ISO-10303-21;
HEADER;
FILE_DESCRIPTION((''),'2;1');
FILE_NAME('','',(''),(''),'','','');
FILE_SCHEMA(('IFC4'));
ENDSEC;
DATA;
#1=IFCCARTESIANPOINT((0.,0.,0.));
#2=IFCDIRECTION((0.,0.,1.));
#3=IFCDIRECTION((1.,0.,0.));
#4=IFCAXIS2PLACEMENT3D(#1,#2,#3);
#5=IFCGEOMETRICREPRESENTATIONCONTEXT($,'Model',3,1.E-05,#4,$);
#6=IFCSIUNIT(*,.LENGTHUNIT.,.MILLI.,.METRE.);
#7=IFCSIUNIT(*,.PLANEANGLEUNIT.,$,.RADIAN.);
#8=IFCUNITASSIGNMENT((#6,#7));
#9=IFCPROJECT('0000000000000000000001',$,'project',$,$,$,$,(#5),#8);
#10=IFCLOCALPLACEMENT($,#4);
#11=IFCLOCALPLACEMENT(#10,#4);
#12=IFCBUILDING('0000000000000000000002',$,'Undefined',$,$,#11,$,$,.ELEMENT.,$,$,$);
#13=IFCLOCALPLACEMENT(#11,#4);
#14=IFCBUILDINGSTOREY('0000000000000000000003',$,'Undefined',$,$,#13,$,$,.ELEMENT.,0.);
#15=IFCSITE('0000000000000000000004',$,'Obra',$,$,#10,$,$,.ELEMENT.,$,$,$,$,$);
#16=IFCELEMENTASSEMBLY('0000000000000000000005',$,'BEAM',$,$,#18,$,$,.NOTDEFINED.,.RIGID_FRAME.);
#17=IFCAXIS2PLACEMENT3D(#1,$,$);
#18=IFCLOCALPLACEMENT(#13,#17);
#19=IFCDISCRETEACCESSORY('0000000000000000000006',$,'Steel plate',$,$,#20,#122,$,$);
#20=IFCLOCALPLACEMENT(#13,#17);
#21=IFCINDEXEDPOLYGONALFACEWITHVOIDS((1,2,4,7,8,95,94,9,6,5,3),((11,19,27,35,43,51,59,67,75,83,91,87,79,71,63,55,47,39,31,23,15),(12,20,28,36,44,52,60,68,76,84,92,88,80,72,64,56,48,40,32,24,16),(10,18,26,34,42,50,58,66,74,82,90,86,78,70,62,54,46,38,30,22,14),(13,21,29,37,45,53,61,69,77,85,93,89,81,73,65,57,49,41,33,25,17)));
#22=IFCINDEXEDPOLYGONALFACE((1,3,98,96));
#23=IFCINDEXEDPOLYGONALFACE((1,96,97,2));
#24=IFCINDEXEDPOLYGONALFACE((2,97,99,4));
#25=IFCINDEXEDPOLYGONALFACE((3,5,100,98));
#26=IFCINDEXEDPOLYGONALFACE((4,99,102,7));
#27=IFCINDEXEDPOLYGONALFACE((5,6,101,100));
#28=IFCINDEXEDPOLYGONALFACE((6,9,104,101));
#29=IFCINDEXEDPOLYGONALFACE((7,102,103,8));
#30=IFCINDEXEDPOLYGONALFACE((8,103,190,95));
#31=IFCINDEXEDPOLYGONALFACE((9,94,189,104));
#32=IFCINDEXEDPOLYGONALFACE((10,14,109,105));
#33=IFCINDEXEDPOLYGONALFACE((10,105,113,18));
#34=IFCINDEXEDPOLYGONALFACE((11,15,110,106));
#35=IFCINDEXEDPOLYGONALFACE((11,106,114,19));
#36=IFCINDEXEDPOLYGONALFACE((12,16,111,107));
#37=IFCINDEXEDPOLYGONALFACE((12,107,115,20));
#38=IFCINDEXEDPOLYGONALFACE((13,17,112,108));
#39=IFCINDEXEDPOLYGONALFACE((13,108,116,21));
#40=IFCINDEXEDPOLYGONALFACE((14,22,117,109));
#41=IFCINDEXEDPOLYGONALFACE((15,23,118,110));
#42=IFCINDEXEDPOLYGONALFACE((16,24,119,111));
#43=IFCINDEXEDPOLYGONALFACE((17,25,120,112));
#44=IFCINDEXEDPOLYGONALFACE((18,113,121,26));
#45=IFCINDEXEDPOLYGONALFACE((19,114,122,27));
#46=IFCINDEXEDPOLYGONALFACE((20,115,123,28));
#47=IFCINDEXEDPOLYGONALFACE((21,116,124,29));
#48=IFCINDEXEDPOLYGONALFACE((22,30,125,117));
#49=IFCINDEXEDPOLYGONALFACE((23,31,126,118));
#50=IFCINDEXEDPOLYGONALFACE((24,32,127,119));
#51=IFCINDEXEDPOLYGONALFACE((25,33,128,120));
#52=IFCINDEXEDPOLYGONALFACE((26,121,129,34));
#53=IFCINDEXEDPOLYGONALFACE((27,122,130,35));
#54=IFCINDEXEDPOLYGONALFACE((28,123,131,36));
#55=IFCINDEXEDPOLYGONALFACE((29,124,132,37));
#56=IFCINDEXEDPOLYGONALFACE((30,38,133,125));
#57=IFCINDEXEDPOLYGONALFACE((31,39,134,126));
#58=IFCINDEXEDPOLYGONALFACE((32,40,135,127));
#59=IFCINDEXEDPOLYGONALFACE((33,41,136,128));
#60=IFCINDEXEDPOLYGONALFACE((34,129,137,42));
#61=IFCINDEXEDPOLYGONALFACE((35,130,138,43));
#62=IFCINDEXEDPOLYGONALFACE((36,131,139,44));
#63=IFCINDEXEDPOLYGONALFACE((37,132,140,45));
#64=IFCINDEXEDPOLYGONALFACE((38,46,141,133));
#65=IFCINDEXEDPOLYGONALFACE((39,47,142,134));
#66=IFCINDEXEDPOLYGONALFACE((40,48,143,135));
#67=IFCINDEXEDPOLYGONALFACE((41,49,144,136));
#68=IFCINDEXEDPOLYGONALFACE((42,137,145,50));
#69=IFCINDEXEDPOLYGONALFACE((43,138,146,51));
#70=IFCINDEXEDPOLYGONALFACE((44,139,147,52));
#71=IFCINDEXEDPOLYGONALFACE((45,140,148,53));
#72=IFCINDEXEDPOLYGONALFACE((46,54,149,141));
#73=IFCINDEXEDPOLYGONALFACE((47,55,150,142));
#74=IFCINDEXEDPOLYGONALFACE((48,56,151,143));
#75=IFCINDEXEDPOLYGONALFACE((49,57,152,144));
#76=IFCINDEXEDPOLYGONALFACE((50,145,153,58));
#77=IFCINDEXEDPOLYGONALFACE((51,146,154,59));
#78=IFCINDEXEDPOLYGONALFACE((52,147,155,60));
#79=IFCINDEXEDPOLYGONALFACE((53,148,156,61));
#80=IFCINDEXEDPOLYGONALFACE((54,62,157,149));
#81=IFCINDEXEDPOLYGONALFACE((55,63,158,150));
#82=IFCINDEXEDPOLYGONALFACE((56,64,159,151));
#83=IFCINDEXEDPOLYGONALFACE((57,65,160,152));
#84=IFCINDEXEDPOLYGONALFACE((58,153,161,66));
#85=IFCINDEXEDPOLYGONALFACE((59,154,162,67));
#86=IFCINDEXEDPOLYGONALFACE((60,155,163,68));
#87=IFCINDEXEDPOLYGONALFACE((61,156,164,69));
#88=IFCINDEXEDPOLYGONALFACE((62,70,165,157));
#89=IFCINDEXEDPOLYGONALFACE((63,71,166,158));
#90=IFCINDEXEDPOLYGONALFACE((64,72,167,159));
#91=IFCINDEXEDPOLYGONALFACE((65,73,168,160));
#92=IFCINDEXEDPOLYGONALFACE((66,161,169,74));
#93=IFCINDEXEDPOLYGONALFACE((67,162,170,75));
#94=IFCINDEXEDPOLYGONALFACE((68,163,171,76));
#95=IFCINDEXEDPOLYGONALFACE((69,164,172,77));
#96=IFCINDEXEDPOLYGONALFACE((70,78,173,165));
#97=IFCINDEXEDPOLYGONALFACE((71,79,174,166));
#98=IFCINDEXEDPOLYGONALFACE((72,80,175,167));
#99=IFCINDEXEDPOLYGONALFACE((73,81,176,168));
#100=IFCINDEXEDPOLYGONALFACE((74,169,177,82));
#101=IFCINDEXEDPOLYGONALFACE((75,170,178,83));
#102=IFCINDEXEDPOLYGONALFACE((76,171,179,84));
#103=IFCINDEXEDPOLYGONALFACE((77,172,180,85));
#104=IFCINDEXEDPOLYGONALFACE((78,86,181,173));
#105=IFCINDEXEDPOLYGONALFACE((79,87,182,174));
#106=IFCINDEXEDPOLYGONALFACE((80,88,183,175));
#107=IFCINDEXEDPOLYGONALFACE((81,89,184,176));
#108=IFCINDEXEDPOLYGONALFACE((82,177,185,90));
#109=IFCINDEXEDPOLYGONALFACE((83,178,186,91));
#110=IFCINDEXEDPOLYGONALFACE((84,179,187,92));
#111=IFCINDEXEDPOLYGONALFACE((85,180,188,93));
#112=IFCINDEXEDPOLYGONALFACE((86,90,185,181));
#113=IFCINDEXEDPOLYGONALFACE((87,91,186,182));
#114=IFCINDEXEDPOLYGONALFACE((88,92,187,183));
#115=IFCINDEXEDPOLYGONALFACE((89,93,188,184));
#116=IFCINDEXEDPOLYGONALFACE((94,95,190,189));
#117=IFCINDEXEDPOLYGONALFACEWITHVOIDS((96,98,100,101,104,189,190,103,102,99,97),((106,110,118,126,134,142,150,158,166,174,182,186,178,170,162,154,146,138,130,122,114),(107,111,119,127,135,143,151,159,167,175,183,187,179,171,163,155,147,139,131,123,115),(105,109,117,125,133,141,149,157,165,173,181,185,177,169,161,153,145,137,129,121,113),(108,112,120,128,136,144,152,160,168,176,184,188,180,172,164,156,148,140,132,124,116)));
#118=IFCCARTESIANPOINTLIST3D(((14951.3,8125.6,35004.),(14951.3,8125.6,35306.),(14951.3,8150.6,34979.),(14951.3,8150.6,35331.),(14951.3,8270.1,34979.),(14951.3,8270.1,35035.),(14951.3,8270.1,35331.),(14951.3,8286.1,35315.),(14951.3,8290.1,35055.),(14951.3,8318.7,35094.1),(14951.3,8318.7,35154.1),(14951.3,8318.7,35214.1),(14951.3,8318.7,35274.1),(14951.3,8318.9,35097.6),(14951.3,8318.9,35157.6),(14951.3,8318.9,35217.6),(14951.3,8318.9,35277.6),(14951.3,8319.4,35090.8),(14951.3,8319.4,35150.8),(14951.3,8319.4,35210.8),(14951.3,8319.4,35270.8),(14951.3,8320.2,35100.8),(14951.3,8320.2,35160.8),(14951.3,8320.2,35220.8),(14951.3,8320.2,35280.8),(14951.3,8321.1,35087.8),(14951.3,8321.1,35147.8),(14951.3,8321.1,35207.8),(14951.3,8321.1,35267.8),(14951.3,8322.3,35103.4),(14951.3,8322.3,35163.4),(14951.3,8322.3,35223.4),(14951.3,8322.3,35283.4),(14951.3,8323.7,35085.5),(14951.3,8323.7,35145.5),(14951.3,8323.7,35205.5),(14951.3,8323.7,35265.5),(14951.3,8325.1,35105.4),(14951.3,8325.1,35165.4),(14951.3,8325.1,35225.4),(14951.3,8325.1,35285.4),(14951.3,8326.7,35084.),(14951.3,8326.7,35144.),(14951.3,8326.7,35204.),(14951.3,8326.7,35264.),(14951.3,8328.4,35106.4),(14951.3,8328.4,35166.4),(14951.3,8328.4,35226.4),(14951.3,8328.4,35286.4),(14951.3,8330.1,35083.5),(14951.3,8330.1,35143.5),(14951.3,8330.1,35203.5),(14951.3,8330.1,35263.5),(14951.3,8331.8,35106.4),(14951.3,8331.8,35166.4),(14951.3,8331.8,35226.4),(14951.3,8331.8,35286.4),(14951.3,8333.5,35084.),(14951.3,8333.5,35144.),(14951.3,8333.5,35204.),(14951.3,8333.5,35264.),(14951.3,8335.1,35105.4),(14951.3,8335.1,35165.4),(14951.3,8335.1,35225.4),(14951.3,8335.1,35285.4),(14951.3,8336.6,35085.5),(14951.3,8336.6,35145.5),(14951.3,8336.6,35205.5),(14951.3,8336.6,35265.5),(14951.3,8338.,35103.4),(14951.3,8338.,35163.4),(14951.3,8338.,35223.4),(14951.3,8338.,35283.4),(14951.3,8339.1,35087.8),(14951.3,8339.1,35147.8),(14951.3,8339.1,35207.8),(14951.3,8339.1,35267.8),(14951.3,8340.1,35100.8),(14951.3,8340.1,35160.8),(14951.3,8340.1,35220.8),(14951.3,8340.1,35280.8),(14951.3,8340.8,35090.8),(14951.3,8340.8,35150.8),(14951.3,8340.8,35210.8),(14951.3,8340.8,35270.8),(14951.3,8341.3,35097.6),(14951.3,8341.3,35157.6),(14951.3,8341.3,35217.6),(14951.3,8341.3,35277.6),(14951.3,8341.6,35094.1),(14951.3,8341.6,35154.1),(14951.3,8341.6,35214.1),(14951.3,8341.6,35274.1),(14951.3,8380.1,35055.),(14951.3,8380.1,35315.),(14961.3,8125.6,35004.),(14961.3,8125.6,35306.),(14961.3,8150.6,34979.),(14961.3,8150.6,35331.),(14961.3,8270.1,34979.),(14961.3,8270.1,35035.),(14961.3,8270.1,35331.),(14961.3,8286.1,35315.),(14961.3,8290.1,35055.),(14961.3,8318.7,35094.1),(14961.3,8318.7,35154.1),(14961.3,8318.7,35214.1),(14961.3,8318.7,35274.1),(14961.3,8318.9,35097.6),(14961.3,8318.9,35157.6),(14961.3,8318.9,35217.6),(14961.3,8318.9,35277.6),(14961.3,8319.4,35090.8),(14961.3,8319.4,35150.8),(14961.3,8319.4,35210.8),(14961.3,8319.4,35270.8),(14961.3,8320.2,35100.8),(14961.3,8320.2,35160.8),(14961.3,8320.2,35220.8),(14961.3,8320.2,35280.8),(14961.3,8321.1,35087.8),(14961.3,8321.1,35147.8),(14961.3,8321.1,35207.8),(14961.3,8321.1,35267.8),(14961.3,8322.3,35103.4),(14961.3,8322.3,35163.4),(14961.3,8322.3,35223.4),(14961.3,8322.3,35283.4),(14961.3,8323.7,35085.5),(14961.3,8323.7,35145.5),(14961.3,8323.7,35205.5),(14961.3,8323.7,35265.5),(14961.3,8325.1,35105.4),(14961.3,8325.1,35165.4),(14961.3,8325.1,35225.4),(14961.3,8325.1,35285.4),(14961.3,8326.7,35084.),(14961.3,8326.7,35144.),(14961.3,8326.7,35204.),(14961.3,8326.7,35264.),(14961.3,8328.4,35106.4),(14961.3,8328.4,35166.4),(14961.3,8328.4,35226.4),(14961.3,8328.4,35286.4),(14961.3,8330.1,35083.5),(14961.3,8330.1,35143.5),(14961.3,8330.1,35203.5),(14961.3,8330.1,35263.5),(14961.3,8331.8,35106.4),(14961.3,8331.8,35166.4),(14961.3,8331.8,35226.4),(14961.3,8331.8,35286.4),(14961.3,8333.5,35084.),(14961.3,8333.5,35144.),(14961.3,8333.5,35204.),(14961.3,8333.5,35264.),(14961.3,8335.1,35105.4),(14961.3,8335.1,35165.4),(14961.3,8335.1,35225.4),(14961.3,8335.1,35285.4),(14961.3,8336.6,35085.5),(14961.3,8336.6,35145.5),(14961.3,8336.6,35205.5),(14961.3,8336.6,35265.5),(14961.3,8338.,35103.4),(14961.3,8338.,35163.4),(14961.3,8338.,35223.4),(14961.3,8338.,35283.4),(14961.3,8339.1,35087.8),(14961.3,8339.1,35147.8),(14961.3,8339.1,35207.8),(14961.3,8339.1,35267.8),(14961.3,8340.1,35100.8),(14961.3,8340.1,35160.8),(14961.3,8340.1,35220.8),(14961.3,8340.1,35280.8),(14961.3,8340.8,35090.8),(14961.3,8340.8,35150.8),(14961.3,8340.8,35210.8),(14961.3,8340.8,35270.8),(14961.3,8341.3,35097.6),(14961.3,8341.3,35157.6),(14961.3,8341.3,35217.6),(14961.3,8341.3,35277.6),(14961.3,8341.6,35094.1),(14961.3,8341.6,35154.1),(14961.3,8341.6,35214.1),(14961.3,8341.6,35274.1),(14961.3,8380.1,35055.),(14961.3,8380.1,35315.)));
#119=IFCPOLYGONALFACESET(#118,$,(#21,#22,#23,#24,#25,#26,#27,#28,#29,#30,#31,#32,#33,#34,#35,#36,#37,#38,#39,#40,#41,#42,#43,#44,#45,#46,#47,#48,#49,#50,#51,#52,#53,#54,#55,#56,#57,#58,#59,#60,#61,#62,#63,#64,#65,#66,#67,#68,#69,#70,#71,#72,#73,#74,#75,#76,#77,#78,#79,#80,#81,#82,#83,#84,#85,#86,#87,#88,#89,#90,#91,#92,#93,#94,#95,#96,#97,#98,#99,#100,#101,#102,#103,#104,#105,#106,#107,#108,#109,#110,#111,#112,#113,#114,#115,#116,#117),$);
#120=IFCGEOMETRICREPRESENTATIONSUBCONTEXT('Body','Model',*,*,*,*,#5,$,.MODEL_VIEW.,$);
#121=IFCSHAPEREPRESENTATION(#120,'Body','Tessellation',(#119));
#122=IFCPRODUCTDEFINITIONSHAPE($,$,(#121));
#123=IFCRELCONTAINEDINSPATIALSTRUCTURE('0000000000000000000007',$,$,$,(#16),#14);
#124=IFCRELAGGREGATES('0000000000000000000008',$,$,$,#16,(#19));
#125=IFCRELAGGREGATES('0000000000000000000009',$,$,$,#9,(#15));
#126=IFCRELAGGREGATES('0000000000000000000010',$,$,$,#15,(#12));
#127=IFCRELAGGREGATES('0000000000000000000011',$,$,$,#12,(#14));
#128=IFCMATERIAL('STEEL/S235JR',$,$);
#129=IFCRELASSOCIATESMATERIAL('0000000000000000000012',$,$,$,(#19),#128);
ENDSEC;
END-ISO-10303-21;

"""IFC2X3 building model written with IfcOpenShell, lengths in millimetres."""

from ifc_helpers import new_model, si_unit, frame, origin_with_axes, origin_2d_with_axis, place, context, subcontext, project, spatial, polyline, circle, outline, extrude, source, transform, mapped, material, element, aggregate, save


model = new_model("IFC2X3")

# Units and contexts
model_context = context("Model", 3, precision=1e-05, world=origin_with_axes())
body_context = subcontext(model_context, "Body", "Model", "MODEL_VIEW")
ifc_project = project(units=[si_unit("LENGTHUNIT", "METRE", prefix="MILLI"), si_unit("PLANEANGLEUNIT", "RADIAN")], contexts=[model_context])

# Site, building, storey
site_placement = place(None, origin_with_axes())
site = spatial("IfcSite", under=ifc_project, at=site_placement, Name="Obra", CompositionType="ELEMENT")
building_placement = place(site_placement, origin_with_axes())
building = spatial("IfcBuilding", under=site, at=building_placement, Name="Undefined", CompositionType="ELEMENT")
storey_placement = place(building_placement, origin_with_axes())
storey = spatial("IfcBuildingStorey", under=building, at=storey_placement, Name="Undefined", CompositionType="ELEMENT", Elevation=0.0)

# Shared definitions
ifc_material_1 = material(Name="STEEL/S235JR")

# Element assembly
assembly_1_placement = place(storey_placement, origin_with_axes())
assembly_1 = element("IfcElementAssembly", 1, at=assembly_1_placement, inside=storey, Name="BEAM", AssemblyPlace="NOTDEFINED", PredefinedType="RIGID_FRAME")

# Discrete accessory, opening
discrete_accessory_1_placement = place(assembly_1_placement, frame((14956.3, 8125.6, 35004.0), z_axis=(1.0, 0.0, 0.0), x_axis=(0.0, 0.707107, -0.707107)))
discrete_accessory_1 = element("IfcDiscreteAccessory", 2, at=discrete_accessory_1_placement, material=ifc_material_1, Name="Steel plate", context=body_context, shape_type="SweptSolid", body=[
    extrude(outline(polyline([(0.0, 0.0), (35.4, 0.0), (119.9, 84.5), (80.3, 124.1), (80.3, 152.4), (143.9, 216.0), (-40.0, 399.9), (-106.4, 333.4), (-129.0, 333.4), (-129.0, 333.4), (-213.5, 248.9), (-213.5, 213.5), (0.0, 0.0)])), frame((0.0, 0.0, -5.0), z_axis=(0.0, 0.0, 1.0), x_axis=(1.0, 0.0, 0.0)), (0.0, 0.0, 1.0), 10.0),
])
shared_shape_1 = source(origin_with_axes(), body_context, "Body", "SweptSolid", [
    extrude(circle(Radius=11.5, at=origin_2d_with_axis()), frame((0.0, -13.8, 0.0), z_axis=(0.0, 1.0, 0.0), x_axis=(1.0, 0.0, 0.0)), (0.0, 0.0, 1.0), 10.2),
])
opening_1_placement = place(assembly_1_placement, frame((14947.7, 8280.1, 35315.0), z_axis=(0.0, 1.0, 0.0), x_axis=(0.0, 0.0, -1.0)))
element("IfcOpeningElement", 3, at=opening_1_placement, cuts=discrete_accessory_1, ObjectType="Opening", context=body_context, shape_type="MappedRepresentation", body=[
    mapped(shared_shape_1, transform((40.0, 0.0, 50.0))),
    mapped(shared_shape_1, transform((100.0, 0.0, 50.0))),
    mapped(shared_shape_1, transform((160.0, 0.0, 50.0))),
    mapped(shared_shape_1, transform((220.0, 0.0, 50.0))),
])
aggregate(assembly_1, [discrete_accessory_1])

save(model, "model.ifc")
